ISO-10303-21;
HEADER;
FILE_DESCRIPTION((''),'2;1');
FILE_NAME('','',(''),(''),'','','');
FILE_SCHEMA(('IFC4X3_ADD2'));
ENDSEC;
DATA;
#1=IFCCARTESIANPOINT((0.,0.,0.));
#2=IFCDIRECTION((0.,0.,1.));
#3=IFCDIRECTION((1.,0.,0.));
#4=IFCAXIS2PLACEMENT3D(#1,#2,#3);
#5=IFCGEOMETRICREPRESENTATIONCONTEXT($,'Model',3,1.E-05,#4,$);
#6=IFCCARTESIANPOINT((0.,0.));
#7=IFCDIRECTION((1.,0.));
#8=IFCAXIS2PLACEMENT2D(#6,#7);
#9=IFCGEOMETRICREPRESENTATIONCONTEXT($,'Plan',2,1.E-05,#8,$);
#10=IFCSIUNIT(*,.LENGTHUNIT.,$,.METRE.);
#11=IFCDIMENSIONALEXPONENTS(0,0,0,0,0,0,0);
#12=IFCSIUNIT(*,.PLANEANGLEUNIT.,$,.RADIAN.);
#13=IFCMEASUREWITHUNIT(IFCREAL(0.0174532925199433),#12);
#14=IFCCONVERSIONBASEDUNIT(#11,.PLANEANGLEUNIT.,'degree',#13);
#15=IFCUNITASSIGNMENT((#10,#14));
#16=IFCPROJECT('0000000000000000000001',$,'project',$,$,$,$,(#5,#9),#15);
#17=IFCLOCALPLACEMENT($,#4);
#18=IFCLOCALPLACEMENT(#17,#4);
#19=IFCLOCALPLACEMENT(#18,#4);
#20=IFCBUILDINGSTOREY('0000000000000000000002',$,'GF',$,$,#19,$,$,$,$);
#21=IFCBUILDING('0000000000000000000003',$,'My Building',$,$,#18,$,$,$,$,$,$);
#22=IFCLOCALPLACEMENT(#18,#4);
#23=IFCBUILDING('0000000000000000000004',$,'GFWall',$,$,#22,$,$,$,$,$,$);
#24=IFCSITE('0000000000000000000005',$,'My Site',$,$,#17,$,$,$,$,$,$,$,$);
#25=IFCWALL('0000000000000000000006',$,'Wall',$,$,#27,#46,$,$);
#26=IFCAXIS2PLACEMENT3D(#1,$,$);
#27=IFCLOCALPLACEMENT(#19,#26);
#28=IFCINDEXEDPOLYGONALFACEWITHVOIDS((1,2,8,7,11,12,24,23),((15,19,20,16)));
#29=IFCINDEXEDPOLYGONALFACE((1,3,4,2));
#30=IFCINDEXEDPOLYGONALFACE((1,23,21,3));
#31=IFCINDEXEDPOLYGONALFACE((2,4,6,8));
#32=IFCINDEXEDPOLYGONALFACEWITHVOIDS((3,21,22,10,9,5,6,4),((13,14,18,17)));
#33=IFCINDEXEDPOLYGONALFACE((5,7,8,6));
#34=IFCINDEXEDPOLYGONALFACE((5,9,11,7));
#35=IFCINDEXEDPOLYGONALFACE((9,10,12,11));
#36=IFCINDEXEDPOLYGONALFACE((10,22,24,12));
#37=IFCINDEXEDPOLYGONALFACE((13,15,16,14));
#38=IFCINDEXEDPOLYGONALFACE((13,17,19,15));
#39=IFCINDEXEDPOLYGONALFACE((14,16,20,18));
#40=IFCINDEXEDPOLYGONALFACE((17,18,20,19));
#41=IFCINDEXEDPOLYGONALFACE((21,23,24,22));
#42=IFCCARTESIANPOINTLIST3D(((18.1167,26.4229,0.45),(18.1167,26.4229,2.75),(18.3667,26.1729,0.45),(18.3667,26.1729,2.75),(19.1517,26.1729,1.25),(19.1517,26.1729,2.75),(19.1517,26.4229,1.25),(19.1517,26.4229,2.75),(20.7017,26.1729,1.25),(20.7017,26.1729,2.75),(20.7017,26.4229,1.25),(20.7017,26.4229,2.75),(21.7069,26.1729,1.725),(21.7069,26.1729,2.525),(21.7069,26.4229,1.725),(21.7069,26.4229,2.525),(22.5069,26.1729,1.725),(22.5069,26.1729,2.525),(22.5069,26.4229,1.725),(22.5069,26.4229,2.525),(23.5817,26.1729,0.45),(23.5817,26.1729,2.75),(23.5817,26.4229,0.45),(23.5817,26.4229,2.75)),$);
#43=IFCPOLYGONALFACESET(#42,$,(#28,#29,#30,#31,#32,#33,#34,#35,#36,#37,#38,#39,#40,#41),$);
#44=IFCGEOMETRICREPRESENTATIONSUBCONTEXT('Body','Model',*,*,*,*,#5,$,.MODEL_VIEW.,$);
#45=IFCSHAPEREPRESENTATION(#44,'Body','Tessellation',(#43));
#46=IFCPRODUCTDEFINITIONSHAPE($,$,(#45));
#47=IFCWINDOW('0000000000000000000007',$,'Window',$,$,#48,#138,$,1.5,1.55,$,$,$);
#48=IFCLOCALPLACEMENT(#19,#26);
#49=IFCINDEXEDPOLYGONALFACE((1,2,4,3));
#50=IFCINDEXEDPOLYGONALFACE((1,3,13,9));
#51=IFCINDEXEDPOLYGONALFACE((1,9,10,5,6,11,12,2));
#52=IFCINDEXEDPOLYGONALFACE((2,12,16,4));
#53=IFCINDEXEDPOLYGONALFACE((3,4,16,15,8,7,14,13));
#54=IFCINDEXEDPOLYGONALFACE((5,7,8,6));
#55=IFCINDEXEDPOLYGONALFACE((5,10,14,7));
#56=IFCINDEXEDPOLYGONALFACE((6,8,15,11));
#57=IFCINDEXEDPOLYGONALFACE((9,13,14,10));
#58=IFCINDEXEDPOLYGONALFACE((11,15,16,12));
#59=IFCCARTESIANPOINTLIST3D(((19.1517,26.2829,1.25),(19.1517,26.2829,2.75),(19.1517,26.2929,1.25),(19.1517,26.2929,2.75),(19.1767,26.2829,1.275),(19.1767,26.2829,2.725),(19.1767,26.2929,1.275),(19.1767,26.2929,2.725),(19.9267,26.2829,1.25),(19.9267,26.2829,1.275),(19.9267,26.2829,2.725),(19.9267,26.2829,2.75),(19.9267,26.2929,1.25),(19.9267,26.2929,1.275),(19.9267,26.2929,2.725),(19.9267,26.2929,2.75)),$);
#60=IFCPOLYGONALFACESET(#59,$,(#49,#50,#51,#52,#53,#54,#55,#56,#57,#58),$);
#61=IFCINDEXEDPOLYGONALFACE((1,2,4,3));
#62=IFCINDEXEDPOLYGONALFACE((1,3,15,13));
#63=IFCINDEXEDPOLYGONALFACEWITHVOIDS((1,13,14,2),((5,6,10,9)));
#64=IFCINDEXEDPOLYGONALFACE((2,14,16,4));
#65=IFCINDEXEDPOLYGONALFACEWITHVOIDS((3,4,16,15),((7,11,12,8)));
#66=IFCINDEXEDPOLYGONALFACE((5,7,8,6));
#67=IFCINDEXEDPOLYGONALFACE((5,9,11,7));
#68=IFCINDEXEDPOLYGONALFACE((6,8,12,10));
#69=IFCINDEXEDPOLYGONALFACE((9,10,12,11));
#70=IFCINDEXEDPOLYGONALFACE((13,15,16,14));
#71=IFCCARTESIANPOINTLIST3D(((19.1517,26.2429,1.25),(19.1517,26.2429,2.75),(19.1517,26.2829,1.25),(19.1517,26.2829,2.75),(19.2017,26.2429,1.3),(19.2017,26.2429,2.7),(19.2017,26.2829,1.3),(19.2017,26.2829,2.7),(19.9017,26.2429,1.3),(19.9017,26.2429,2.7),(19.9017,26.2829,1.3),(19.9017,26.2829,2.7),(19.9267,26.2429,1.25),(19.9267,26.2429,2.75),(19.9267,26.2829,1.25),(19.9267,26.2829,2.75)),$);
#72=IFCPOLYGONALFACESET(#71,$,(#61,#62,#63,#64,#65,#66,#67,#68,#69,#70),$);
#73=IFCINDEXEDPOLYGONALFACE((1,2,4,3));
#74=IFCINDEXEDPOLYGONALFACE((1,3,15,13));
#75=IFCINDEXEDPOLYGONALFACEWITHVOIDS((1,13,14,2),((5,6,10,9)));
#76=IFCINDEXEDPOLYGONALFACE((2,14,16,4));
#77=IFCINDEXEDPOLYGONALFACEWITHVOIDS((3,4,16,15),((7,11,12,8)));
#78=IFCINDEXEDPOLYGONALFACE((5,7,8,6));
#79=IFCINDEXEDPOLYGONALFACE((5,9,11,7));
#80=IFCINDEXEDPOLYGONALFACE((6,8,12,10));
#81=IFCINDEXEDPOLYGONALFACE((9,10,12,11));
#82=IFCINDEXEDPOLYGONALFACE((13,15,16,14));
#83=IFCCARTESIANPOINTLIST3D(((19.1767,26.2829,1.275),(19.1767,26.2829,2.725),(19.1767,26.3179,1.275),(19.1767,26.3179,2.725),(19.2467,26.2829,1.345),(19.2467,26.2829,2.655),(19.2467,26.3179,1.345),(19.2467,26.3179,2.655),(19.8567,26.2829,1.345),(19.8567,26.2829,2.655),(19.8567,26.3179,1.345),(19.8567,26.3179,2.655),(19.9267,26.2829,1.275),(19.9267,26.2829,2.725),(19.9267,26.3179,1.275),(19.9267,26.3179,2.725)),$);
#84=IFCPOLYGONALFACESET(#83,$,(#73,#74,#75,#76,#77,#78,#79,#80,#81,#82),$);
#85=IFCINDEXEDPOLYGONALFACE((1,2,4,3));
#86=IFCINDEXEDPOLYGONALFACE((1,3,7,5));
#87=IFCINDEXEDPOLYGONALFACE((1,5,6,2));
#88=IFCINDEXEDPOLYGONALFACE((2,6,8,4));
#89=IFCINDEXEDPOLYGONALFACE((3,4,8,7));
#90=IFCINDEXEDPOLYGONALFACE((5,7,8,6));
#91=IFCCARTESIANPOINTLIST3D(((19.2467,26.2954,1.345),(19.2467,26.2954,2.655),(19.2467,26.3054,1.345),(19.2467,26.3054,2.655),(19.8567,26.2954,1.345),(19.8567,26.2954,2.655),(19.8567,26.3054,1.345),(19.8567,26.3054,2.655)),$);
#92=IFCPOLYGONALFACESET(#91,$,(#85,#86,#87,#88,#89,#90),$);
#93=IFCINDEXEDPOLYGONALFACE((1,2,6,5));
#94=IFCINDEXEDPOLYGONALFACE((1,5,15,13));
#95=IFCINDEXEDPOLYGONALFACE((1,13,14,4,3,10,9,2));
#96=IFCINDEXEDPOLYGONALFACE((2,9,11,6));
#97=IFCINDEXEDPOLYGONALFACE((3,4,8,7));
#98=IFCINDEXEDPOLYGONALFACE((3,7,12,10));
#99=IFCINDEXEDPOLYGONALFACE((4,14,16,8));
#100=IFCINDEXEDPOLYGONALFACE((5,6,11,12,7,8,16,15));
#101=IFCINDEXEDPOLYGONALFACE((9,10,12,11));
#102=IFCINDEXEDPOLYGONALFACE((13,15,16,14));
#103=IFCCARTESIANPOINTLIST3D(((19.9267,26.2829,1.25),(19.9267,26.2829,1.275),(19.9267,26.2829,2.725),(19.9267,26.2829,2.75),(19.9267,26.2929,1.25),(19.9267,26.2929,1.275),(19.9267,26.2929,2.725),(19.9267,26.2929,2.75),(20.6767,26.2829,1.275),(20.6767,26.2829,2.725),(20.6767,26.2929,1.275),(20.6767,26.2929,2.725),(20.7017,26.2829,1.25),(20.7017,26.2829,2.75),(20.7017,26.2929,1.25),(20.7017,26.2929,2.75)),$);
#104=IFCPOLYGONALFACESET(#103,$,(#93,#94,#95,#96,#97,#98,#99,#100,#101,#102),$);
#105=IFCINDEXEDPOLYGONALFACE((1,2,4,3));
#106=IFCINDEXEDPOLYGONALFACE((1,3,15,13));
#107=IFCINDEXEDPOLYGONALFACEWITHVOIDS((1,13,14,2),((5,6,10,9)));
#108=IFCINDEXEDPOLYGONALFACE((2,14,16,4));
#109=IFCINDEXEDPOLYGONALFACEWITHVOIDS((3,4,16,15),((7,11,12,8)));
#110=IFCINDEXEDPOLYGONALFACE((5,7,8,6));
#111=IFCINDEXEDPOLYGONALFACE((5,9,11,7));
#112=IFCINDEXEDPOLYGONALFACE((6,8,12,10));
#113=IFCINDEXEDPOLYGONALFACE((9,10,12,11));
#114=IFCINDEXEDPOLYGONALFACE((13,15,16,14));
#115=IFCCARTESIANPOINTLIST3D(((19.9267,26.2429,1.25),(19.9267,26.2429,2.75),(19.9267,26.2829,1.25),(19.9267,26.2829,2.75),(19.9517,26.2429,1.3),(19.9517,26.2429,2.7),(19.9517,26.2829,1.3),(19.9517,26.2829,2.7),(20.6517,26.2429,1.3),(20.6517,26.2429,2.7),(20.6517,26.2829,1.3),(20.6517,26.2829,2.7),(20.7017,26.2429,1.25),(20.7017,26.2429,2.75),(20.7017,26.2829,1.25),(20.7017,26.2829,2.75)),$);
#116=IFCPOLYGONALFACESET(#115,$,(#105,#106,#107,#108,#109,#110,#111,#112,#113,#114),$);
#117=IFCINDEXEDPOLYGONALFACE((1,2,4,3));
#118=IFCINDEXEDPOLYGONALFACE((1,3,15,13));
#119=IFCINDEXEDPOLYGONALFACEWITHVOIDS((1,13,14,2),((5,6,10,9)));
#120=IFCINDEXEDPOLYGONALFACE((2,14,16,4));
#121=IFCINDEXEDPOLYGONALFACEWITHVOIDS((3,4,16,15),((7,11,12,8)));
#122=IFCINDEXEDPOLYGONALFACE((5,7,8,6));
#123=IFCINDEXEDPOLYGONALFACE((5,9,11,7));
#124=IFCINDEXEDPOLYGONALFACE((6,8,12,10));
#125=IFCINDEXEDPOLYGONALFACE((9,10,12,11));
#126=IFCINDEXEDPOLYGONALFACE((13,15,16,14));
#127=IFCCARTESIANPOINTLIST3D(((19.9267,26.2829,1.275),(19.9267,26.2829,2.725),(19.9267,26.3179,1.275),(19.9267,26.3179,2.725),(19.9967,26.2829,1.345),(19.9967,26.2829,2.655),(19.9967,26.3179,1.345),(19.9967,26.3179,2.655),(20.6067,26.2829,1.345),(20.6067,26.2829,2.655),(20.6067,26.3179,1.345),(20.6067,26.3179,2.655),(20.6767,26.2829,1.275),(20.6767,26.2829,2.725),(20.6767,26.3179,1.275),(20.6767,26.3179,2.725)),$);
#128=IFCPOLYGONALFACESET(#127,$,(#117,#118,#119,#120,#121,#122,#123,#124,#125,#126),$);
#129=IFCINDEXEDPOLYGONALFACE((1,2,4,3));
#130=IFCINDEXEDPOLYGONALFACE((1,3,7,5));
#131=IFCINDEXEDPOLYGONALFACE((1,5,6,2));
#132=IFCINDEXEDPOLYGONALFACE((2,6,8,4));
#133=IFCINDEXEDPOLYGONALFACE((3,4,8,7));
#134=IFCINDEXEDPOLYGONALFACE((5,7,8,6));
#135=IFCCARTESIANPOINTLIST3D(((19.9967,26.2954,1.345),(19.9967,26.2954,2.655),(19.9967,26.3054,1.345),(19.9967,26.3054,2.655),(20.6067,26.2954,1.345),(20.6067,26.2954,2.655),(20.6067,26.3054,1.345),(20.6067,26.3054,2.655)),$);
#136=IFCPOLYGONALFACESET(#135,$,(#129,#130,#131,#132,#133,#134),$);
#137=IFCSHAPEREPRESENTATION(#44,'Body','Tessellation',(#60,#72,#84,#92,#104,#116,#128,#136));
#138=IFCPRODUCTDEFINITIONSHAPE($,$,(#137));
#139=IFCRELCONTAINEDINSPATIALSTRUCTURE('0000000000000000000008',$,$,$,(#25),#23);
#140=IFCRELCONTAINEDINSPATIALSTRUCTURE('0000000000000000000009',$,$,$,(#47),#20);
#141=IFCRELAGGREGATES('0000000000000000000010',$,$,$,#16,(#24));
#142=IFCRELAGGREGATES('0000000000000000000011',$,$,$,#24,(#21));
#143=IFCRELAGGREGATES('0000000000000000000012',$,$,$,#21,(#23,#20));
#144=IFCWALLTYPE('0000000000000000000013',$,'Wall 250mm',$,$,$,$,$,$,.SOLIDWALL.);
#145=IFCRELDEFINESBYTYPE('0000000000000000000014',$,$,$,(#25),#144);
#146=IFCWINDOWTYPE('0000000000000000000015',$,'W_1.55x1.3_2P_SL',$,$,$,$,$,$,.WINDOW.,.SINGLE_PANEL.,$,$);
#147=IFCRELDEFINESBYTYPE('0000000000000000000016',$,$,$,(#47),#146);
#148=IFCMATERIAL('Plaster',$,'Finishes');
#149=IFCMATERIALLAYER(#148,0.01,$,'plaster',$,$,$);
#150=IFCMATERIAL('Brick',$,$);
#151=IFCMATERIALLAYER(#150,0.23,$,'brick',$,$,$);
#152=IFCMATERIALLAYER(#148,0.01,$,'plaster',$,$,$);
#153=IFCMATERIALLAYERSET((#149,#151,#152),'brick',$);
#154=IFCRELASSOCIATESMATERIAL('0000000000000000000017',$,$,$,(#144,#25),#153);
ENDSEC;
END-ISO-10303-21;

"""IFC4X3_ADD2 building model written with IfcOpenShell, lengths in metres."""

from ifc_helpers import new_model, entity, si_unit, converted_unit, frame, origin_with_axes, origin_2d_with_axis, place, context, subcontext, project, spatial, line, indexed_curve, outline, extrude, shape, source, transform, mapped, material, layer, layer_set, layer_usage, type_object, type_shapes, element, fill, save


model = new_model("IFC4X3_ADD2")

# Units and contexts
model_context = context("Model", 3, precision=1e-05, world=origin_with_axes())
plan_context = context("Plan", 2, precision=1e-05, world=origin_2d_with_axis())
body_context_1 = subcontext(model_context, "Body", "Model", "MODEL_VIEW")
body_context_2 = subcontext(plan_context, "Body", "Plan", "PLAN_VIEW")
ifc_project = project(units=[si_unit("LENGTHUNIT", "METRE"), converted_unit("PLANEANGLEUNIT", "degree", entity("IfcReal", 0.0174532925199433), si_unit("PLANEANGLEUNIT", "RADIAN"), dimensions=[0, 0, 0, 0, 0, 0, 0])], contexts=[model_context, plan_context])

# Site, buildings
site_placement = place(None, origin_with_axes())
site = spatial("IfcSite", under=ifc_project, at=site_placement, Name="My Site")
building_1_placement = place(site_placement, origin_with_axes())
building_1 = spatial("IfcBuilding", under=site, at=building_1_placement, Name="My Building")
building_2_placement = place(building_1_placement, origin_with_axes())
building_2 = spatial("IfcBuilding", under=building_1, at=building_2_placement, Name="GFWall")

# Shared definitions
ifc_material_1 = material(Name="Plaster", Category="Finishes")
ifc_material_2 = material(Name="Brick")

# Wall, openings
ifc_layer_1 = layer(ifc_material_1, 0.01, Name="plaster")
ifc_layer_2 = layer(ifc_material_2, 0.23, Name="brick")
ifc_layer_3 = layer(ifc_material_1, 0.01, Name="plaster")
ifc_layer_set_1 = layer_set([ifc_layer_1, ifc_layer_2, ifc_layer_3], Name="brick")
ifc_layer_usage_1 = layer_usage(ifc_layer_set_1, "AXIS2", "POSITIVE", 0.0)
wall_type_1 = type_object("IfcWallType", Name="Wall 250mm", PredefinedType="SOLIDWALL", material=ifc_layer_set_1)
wall_1_placement = place(building_2_placement, frame((18.3667, 26.1729, 0.45), z_axis=(0.0, 0.0, 1.0), x_axis=(1.0, 0.0, 0.0)))
wall_1 = element("IfcWall", 1, at=wall_1_placement, inside=building_2, type_object=wall_type_1, material=ifc_layer_usage_1, Name="Wall", context=body_context_1, shape_type="SweptSolid", body=[
    extrude(outline(indexed_curve([(0.0, 0.0), (-0.25, 0.25), (5.215, 0.25), (5.215, 0.0)], segments=[line(1, 2, 3, 4, 1)])), origin_with_axes(), (0.0, 0.0, 1.0), 2.3),
])
shared_shape_1 = source(origin_with_axes(), body_context_1, "Body", "SweptSolid", [
    extrude(outline(indexed_curve([(0.0, 0.0), (1.55, 0.0), (1.55, 1.5), (0.0, 1.5)], segments=[line(1, 2, 3, 4, 1)])), frame((0.0, -0.6, 0.0), z_axis=(0.0, -1.0, 0.0), x_axis=(1.0, 0.0, 0.0)), (0.0, 0.0, -1.0), 1.2),
])
opening_1_placement = place(wall_1_placement, frame((0.785, 0.02, 0.8), z_axis=(0.0, 0.0, 1.0), x_axis=(1.0, 0.0, 0.0)))
opening_1 = element("IfcOpeningElement", 2, at=opening_1_placement, cuts=wall_1, PredefinedType="OPENING", context=body_context_1, shape_type="MappedRepresentation", body=[
    mapped(shared_shape_1, transform((0.0, 0.0, 0.0), x_axis=(1.0, 0.0, 0.0), y_axis=(0.0, 1.0, 0.0), z_axis=(0.0, 0.0, 1.0), scale=1.0)),
])
shared_shape_2 = source(origin_with_axes(), body_context_1, "Body", "SweptSolid", [
    extrude(outline(indexed_curve([(0.0, 0.8), (0.0, 0.0), (0.8, 0.0), (0.8, 0.8)], segments=[line(4, 1), line(1, 2), line(2, 3), line(3, 4)], self_intersect=False)), frame((-0.4, -0.6, 0.0), z_axis=(0.0, -1.0, 0.0), x_axis=(1.0, 0.0, 0.0)), (0.0, 0.0, -1.0), 1.2),
])
opening_2_placement = place(wall_1_placement, frame((3.7402, 0.0, 1.275), z_axis=(0.0, 0.0, 1.0), x_axis=(1.0, 0.0, 0.0)))
element("IfcOpeningElement", 3, at=opening_2_placement, cuts=wall_1, PredefinedType="OPENING", context=body_context_1, shape_type="MappedRepresentation", body=[
    mapped(shared_shape_2, transform((0.0, 0.0, 0.0), x_axis=(1.0, 0.0, 0.0), y_axis=(0.0, 1.0, 0.0), z_axis=(0.0, 0.0, 1.0), scale=1.0)),
])

# Shared definitions
storey_placement = place(building_1_placement, origin_with_axes())
storey = spatial("IfcBuildingStorey", under=building_1, at=storey_placement, Name="GF")

# Window
window_type = type_object("IfcWindowType", Name="W_1.55x1.3_2P_SL", PartitioningType="SINGLE_PANEL", PredefinedType="WINDOW")
shared_shape_3 = source(origin_with_axes(), body_context_1, "Body", "SweptSolid", [
    extrude(outline(indexed_curve([(0.775, 0.0), (0.0, 0.0), (0.0, 1.5), (0.775, 1.5), (0.775, 1.475), (0.025, 1.475), (0.025, 0.025), (0.775, 0.025)], segments=[line(1, 2, 3, 4, 5, 6, 7, 8, 1)])), frame((0.0, 0.09, 0.0), z_axis=(0.0, -1.0, 0.0), x_axis=(1.0, 0.0, 0.0)), (0.0, 0.0, -1.0), 0.01),
    extrude(outline(indexed_curve([(0.0, 0.0), (0.775, 0.0), (0.775, 1.5), (0.0, 1.5)], segments=[line(1, 2, 3, 4, 1)]), holes=[indexed_curve([(0.05, 0.05), (0.75, 0.05), (0.75, 1.45), (0.05, 1.45)], segments=[line(1, 2, 3, 4, 1)])]), frame((0.0, 0.05, 0.0), z_axis=(0.0, -1.0, 0.0), x_axis=(1.0, 0.0, 0.0)), (0.0, 0.0, -1.0), 0.04),
    extrude(outline(indexed_curve([(0.0, 0.0), (0.75, 0.0), (0.75, 1.45), (0.0, 1.45)], segments=[line(1, 2, 3, 4, 1)]), holes=[indexed_curve([(0.07, 0.07), (0.68, 0.07), (0.68, 1.38), (0.07, 1.38)], segments=[line(1, 2, 3, 4, 1)])]), frame((0.025, 0.09, 0.025), z_axis=(0.0, -1.0, 0.0), x_axis=(1.0, 0.0, 0.0)), (0.0, 0.0, -1.0), 0.035),
    extrude(outline(indexed_curve([(0.07, 0.07), (0.68, 0.07), (0.68, 1.38), (0.07, 1.38)], segments=[line(1, 2, 3, 4, 1)])), frame((0.025, 0.1025, 0.025), z_axis=(0.0, -1.0, 0.0), x_axis=(1.0, 0.0, 0.0)), (0.0, 0.0, -1.0), 0.01),
    extrude(outline(indexed_curve([(0.0, 1.5), (0.775, 1.5), (0.775, 0.0), (0.0, 0.0), (0.0, 0.025), (0.75, 0.025), (0.75, 1.475), (0.0, 1.475)], segments=[line(1, 2, 3, 4, 5, 6, 7, 8, 1)])), frame((0.775, 0.09, 0.0), z_axis=(0.0, -1.0, 0.0), x_axis=(1.0, 0.0, 0.0)), (0.0, 0.0, -1.0), 0.01),
    extrude(outline(indexed_curve([(0.0, 0.0), (0.775, 0.0), (0.775, 1.5), (0.0, 1.5)], segments=[line(1, 2, 3, 4, 1)]), holes=[indexed_curve([(0.025, 0.05), (0.725, 0.05), (0.725, 1.45), (0.025, 1.45)], segments=[line(1, 2, 3, 4, 1)])]), frame((0.775, 0.05, 0.0), z_axis=(0.0, -1.0, 0.0), x_axis=(1.0, 0.0, 0.0)), (0.0, 0.0, -1.0), 0.04),
    extrude(outline(indexed_curve([(0.0, 0.0), (0.75, 0.0), (0.75, 1.45), (0.0, 1.45)], segments=[line(1, 2, 3, 4, 1)]), holes=[indexed_curve([(0.07, 0.07), (0.68, 0.07), (0.68, 1.38), (0.07, 1.38)], segments=[line(1, 2, 3, 4, 1)])]), frame((0.775, 0.09, 0.025), z_axis=(0.0, -1.0, 0.0), x_axis=(1.0, 0.0, 0.0)), (0.0, 0.0, -1.0), 0.035),
    extrude(outline(indexed_curve([(0.07, 0.07), (0.68, 0.07), (0.68, 1.38), (0.07, 1.38)], segments=[line(1, 2, 3, 4, 1)])), frame((0.775, 0.1025, 0.025), z_axis=(0.0, -1.0, 0.0), x_axis=(1.0, 0.0, 0.0)), (0.0, 0.0, -1.0), 0.01),
])
shared_shape_4 = source(origin_with_axes(), body_context_2, "Body", "Curve2D", [
    entity("IfcIndexedPolyCurve", entity("IfcCartesianPointList2D", [[0.05, 0.05], [0.75, 0.05]])),
    entity("IfcIndexedPolyCurve", entity("IfcCartesianPointList2D", [[0.0, 0.1], [0.025, 0.1], [0.025, 0.09], [0.05, 0.09], [0.05, 0.05], [0.0, 0.05]]), [entity("IfcLineIndex", [1, 2, 3, 4, 5, 6, 1])]),
    entity("IfcIndexedPolyCurve", entity("IfcCartesianPointList2D", [[0.775, 0.1], [0.775, 0.1], [0.775, 0.09], [0.75, 0.09], [0.75, 0.05], [0.775, 0.05]])),
    entity("IfcIndexedPolyCurve", entity("IfcCartesianPointList2D", [[0.025, 0.09], [0.095, 0.09], [0.095, 0.125], [0.025, 0.125]]), [entity("IfcLineIndex", [1, 2, 3, 4, 1])]),
    entity("IfcIndexedPolyCurve", entity("IfcCartesianPointList2D", [[0.775, 0.09], [0.705, 0.09], [0.705, 0.125], [0.775, 0.125]]), [entity("IfcLineIndex", [1, 2, 3, 4, 1])]),
    entity("IfcIndexedPolyCurve", entity("IfcCartesianPointList2D", [[0.095, 0.09], [0.705, 0.09]])),
    entity("IfcIndexedPolyCurve", entity("IfcCartesianPointList2D", [[0.095, 0.125], [0.705, 0.125]])),
    entity("IfcIndexedPolyCurve", entity("IfcCartesianPointList2D", [[0.095, 0.1075], [0.705, 0.1075]])),
    entity("IfcIndexedPolyCurve", entity("IfcCartesianPointList2D", [[0.8, 0.05], [1.5, 0.05]])),
    entity("IfcIndexedPolyCurve", entity("IfcCartesianPointList2D", [[0.775, 0.1], [0.775, 0.1], [0.775, 0.09], [0.8, 0.09], [0.8, 0.05], [0.775, 0.05]])),
    entity("IfcIndexedPolyCurve", entity("IfcCartesianPointList2D", [[1.55, 0.1], [1.525, 0.1], [1.525, 0.09], [1.5, 0.09], [1.5, 0.05], [1.55, 0.05]]), [entity("IfcLineIndex", [1, 2, 3, 4, 5, 6, 1])]),
    entity("IfcIndexedPolyCurve", entity("IfcCartesianPointList2D", [[0.775, 0.09], [0.845, 0.09], [0.845, 0.125], [0.775, 0.125]]), [entity("IfcLineIndex", [1, 2, 3, 4, 1])]),
    entity("IfcIndexedPolyCurve", entity("IfcCartesianPointList2D", [[1.525, 0.09], [1.455, 0.09], [1.455, 0.125], [1.525, 0.125]]), [entity("IfcLineIndex", [1, 2, 3, 4, 1])]),
    entity("IfcIndexedPolyCurve", entity("IfcCartesianPointList2D", [[0.845, 0.09], [1.455, 0.09]])),
    entity("IfcIndexedPolyCurve", entity("IfcCartesianPointList2D", [[0.845, 0.125], [1.455, 0.125]])),
    entity("IfcIndexedPolyCurve", entity("IfcCartesianPointList2D", [[0.845, 0.1075], [1.455, 0.1075]])),
])
type_shapes(window_type, [shared_shape_3, shared_shape_4])
window_placement = place(opening_1_placement, origin_with_axes())
window = element("IfcWindow", 4, at=window_placement, inside=storey, type_object=window_type, Name="Window", OverallHeight=1.5, OverallWidth=1.55, shapes=[
    shape(body_context_1, "Body", "MappedRepresentation", [mapped(shared_shape_3, transform((0.0, 0.0, 0.0), x_axis=(1.0, 0.0, 0.0), y_axis=(0.0, 1.0, 0.0), z_axis=(0.0, 0.0, 1.0), scale=1.0))]),
    shape(body_context_2, "Body", "MappedRepresentation", [mapped(shared_shape_4, transform((0.0, 0.0, 0.0), x_axis=(1.0, 0.0, 0.0), y_axis=(0.0, 1.0, 0.0), z_axis=(0.0, 0.0, 1.0), scale=1.0))]),
])
fill(opening_1, window)

save(model, "model.ifc")
